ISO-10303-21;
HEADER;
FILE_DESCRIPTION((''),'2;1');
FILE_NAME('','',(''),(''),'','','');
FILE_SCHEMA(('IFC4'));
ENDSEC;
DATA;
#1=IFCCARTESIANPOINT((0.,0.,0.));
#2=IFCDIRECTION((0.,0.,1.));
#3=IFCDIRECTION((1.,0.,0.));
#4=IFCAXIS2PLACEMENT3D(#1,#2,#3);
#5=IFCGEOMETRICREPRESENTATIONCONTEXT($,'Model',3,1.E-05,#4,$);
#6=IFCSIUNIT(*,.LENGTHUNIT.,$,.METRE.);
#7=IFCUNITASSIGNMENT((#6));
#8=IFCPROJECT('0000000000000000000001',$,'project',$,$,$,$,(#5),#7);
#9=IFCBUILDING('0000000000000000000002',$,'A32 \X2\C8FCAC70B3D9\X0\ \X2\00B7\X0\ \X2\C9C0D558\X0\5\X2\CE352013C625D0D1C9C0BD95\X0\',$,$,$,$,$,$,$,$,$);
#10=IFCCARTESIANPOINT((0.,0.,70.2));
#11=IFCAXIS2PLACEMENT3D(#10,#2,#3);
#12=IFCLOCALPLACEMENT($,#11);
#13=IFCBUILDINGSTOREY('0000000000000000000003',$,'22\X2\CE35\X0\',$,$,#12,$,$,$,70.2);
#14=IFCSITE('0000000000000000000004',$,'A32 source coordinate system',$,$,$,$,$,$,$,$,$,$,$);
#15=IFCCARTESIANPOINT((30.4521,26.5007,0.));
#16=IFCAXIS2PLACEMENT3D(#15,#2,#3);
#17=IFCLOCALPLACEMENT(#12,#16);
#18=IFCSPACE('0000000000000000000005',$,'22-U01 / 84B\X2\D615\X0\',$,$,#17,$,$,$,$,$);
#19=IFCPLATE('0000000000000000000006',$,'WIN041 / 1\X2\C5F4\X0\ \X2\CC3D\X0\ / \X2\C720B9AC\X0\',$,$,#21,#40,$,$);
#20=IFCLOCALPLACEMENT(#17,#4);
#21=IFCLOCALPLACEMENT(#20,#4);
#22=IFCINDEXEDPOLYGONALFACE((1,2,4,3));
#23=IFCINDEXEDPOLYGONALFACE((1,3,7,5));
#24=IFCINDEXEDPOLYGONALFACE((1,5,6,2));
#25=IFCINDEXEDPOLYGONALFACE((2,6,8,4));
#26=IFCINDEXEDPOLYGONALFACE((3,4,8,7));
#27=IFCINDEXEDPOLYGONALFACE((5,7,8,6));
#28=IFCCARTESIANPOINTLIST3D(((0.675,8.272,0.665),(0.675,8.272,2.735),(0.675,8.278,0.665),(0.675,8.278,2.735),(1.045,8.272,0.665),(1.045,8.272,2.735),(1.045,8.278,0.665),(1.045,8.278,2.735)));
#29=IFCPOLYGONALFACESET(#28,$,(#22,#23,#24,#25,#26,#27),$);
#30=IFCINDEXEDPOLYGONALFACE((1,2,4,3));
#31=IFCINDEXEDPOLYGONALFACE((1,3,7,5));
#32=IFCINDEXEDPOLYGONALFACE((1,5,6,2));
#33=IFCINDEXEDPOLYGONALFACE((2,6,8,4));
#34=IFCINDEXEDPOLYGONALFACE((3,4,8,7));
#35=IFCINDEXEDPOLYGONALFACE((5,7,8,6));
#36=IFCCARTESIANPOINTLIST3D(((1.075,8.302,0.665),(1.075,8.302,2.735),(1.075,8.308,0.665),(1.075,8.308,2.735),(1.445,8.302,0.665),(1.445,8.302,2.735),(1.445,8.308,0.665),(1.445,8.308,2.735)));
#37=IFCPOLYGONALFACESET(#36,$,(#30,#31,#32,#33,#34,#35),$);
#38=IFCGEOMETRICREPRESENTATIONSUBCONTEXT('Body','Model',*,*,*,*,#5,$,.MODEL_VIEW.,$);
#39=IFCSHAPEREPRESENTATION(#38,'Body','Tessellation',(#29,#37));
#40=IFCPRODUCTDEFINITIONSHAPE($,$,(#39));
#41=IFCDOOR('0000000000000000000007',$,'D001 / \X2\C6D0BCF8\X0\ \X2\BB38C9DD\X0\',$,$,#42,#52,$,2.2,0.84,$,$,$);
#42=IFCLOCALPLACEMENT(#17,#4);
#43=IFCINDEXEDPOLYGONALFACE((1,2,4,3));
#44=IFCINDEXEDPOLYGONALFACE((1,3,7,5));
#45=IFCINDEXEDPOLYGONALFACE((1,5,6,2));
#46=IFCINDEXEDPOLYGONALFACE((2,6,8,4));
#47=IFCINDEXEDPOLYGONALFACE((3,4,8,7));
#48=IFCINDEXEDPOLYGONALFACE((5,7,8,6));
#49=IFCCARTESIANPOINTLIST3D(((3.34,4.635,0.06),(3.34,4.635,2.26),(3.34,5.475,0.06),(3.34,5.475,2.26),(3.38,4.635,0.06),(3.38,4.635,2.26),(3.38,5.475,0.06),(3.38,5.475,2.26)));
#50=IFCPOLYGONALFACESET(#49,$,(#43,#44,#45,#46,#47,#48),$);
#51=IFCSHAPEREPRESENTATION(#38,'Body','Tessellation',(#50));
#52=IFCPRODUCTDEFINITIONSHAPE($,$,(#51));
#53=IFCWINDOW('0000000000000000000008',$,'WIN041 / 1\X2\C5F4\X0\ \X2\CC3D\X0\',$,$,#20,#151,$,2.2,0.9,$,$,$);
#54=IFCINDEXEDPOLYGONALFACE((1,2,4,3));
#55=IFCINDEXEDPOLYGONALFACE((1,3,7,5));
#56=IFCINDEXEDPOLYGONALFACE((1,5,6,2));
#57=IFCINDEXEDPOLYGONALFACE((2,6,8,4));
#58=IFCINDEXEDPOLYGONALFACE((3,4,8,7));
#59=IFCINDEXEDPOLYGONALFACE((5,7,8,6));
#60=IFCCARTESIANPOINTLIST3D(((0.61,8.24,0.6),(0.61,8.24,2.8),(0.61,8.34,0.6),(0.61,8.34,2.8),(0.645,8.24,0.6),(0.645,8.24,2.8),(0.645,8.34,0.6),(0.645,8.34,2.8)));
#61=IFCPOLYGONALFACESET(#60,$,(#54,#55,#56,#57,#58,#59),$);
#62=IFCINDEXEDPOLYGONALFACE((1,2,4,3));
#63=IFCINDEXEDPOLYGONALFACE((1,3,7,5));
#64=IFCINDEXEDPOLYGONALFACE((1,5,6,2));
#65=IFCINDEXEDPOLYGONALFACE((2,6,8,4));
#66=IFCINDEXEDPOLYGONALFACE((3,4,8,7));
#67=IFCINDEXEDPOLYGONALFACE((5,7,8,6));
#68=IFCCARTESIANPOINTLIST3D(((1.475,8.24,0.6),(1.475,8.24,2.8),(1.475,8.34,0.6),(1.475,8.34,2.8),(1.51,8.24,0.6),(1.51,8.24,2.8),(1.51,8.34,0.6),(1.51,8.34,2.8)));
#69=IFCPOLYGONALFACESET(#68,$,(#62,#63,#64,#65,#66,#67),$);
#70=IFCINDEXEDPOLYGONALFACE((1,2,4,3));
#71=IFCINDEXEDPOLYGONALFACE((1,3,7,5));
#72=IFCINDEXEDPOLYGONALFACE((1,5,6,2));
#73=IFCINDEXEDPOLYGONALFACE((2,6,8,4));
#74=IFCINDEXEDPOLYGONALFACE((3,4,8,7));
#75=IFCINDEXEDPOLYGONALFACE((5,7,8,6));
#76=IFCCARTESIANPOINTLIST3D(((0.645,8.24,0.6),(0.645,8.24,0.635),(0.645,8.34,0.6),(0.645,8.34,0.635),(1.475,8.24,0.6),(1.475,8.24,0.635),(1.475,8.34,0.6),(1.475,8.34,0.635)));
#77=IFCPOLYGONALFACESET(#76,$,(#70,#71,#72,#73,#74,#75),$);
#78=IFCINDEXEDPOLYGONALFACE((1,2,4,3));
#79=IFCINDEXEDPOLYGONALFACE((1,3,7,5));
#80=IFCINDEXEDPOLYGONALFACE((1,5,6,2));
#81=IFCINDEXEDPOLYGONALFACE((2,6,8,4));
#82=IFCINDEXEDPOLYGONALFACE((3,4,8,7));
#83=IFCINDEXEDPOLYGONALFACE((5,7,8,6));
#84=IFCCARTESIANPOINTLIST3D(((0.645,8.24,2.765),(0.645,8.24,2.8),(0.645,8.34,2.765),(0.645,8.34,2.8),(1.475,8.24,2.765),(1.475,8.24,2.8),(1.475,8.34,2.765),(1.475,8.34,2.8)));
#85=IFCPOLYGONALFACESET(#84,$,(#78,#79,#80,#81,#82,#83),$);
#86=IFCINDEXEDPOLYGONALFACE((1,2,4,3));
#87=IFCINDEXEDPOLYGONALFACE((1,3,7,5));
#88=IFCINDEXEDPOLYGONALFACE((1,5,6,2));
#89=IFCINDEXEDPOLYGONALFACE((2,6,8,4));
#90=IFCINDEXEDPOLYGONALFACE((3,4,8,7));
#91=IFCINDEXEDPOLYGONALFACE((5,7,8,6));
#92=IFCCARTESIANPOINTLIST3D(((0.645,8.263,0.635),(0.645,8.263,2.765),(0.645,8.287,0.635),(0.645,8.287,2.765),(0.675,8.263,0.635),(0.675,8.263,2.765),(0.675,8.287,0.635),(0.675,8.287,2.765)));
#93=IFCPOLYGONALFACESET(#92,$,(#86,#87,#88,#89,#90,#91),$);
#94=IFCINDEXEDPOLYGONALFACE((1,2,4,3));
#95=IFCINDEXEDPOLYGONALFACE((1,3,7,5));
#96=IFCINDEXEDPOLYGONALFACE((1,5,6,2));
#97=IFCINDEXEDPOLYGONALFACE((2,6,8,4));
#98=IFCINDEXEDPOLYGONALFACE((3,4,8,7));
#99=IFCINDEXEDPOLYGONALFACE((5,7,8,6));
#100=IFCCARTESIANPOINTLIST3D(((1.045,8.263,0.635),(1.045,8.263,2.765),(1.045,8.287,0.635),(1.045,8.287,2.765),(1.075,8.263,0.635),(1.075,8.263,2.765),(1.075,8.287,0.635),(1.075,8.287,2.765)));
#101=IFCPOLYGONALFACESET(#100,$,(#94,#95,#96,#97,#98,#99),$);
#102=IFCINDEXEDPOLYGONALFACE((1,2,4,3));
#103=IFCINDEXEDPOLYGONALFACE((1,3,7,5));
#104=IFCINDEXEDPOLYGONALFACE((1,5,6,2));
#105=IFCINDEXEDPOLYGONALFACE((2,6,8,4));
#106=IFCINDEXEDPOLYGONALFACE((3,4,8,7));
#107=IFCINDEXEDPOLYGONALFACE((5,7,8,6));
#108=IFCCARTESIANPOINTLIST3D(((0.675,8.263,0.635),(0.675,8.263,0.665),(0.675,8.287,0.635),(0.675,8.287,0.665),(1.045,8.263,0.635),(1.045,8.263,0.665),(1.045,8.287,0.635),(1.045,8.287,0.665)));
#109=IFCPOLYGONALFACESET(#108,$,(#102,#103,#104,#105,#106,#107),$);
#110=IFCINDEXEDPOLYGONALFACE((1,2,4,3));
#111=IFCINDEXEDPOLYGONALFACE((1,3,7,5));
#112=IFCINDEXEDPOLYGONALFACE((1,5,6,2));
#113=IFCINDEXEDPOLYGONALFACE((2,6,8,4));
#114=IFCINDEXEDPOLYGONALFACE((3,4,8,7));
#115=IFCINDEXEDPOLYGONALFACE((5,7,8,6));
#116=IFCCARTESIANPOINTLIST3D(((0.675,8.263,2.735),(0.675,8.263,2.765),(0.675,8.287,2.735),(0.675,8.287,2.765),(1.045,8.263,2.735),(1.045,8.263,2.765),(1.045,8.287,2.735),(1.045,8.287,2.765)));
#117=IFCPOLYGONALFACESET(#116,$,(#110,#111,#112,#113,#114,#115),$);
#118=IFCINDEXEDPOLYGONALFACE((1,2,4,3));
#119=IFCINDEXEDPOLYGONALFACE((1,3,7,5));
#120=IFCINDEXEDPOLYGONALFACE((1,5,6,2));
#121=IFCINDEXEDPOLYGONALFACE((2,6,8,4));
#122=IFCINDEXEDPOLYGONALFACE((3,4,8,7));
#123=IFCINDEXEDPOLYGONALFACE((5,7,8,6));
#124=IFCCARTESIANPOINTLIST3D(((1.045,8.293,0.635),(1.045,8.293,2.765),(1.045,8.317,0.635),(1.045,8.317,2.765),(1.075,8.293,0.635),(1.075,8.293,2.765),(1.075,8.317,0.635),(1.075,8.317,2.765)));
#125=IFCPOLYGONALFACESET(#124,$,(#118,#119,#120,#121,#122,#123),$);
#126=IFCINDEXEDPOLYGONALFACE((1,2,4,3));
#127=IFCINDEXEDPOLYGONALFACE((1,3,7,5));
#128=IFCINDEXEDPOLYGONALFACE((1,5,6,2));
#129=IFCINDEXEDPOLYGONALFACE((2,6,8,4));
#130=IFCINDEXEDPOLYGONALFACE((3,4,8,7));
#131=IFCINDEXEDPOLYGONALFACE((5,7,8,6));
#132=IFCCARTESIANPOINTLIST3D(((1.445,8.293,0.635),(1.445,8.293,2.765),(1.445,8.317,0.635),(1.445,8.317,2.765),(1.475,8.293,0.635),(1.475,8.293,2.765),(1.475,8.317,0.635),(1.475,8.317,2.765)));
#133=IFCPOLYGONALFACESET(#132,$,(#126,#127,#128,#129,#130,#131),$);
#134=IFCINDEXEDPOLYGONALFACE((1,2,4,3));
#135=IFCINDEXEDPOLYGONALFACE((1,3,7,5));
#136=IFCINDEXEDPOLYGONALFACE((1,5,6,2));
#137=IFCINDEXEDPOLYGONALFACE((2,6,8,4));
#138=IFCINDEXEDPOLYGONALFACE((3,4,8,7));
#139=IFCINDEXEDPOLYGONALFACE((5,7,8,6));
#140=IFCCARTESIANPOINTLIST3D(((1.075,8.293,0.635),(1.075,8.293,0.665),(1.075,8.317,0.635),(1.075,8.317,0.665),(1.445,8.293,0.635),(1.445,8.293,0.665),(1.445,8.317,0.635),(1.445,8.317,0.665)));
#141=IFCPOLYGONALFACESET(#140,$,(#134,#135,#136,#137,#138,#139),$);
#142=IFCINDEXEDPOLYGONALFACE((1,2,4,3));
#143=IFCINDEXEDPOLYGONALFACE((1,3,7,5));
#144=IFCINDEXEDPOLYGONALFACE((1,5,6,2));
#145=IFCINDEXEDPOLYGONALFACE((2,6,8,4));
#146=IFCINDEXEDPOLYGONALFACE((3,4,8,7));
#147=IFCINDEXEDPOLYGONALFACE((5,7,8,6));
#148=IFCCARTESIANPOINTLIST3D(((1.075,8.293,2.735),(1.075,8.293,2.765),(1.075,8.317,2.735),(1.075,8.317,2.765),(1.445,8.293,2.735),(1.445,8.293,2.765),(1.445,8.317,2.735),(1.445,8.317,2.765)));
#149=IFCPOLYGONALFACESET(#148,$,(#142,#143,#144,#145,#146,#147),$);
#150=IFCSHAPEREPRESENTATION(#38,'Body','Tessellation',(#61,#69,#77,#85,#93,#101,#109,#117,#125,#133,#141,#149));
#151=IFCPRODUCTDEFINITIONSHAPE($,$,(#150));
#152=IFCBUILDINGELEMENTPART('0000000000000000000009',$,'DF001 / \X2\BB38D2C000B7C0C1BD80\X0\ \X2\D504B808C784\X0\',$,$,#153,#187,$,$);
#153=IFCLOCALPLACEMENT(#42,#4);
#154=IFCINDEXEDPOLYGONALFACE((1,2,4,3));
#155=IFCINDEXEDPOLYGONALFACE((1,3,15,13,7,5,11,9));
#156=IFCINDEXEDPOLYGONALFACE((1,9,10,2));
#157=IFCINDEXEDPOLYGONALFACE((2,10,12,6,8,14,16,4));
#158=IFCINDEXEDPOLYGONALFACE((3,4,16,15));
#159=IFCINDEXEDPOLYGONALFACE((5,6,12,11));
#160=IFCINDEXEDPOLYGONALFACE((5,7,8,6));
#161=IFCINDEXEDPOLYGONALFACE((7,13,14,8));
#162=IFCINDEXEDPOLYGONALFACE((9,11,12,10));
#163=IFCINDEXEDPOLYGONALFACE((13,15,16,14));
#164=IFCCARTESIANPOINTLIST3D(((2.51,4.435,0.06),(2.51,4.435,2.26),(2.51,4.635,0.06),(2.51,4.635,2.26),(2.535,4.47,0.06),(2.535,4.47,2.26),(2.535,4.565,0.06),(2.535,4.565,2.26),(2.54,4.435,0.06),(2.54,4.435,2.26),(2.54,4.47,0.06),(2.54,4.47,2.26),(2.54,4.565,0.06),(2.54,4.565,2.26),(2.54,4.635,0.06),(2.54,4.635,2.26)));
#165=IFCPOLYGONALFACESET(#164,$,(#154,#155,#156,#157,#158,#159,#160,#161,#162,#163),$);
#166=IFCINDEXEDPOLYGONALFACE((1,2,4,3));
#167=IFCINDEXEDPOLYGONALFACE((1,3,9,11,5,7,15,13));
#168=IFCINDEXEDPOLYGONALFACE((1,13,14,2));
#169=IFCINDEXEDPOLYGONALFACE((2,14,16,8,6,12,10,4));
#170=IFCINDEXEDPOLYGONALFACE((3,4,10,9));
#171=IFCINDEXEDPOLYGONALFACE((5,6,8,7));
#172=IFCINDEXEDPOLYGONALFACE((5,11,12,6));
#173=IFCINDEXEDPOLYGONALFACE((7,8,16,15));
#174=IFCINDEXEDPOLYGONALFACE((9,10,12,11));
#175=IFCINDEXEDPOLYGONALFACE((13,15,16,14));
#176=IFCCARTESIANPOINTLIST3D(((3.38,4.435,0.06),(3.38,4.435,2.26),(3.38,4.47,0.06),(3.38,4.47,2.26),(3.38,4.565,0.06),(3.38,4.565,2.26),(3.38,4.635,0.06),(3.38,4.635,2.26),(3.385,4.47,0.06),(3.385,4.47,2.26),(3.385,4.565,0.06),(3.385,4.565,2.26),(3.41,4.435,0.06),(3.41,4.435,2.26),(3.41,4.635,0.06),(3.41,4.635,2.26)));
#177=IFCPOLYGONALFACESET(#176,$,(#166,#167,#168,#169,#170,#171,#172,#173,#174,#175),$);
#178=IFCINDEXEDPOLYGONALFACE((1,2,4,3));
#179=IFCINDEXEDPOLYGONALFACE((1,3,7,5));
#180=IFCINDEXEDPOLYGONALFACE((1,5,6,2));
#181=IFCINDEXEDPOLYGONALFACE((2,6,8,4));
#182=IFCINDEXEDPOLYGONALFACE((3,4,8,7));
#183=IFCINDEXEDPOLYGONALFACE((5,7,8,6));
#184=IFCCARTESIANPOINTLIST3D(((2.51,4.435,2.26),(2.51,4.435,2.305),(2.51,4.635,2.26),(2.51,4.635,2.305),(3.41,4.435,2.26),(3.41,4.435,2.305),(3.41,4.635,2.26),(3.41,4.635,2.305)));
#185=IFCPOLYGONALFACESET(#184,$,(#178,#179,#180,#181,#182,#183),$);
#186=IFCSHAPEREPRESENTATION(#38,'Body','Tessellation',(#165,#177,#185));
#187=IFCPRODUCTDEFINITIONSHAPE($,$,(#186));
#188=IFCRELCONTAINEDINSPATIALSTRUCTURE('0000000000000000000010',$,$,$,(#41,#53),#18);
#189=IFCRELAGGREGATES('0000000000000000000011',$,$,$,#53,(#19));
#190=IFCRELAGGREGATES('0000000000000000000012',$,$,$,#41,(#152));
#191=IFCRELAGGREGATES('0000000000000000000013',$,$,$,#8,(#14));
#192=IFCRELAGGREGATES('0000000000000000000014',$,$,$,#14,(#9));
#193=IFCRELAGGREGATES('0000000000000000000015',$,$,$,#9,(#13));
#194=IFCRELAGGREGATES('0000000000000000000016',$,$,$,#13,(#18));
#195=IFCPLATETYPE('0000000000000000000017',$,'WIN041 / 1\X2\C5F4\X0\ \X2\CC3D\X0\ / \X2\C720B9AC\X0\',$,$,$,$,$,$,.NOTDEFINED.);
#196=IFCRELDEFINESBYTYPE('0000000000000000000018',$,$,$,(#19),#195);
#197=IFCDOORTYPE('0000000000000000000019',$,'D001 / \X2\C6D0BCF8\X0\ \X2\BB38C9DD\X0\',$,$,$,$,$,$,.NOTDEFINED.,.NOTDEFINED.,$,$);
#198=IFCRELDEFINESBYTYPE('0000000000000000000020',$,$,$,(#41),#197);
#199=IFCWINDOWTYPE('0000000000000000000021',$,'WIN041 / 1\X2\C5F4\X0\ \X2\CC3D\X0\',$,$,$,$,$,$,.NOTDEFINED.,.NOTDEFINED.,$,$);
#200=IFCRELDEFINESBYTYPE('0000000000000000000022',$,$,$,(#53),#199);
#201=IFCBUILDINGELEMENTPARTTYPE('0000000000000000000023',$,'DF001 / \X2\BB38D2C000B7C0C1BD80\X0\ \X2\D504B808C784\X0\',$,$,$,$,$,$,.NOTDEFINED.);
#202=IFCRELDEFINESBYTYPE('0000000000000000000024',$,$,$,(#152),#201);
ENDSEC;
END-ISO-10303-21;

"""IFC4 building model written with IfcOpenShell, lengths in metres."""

from ifc_helpers import new_model, si_unit, frame, origin, origin_with_axes, place, context, subcontext, project, spatial, polyline, outline, extrude, source, transform, mapped, type_object, type_shapes, element, aggregate, save


model = new_model("IFC4")

# Units and contexts
model_context = context("Model", 3, precision=1e-05, world=origin_with_axes())
body_context = subcontext(model_context, "Body", "Model", "MODEL_VIEW")
ifc_project = project(units=[si_unit("LENGTHUNIT", "METRE")], contexts=[model_context])

# Plate
storey_placement = place(None, frame((0.0, 0.0, 70.2), z_axis=(0.0, 0.0, 1.0), x_axis=(1.0, 0.0, 0.0)))
space_placement = place(storey_placement, frame((30.4521, 26.5007, 0.0), z_axis=(0.0, 0.0, 1.0), x_axis=(1.0, 0.0, 0.0)))
plate_type_1 = type_object("IfcPlateType", Name="WIN041 / 1열 창 / 유리", PredefinedType="NOTDEFINED")
shared_shape_1 = source(origin(), body_context, "Body", "SweptSolid", [
    extrude(outline(polyline([(0.675, 8.272), (0.675, 8.278), (1.045, 8.278), (1.045, 8.272), (0.675, 8.272)])), frame((0.0, 0.0, 0.665)), (0.0, 0.0, 1.0), 2.07),
    extrude(outline(polyline([(1.075, 8.302), (1.075, 8.308), (1.445, 8.308), (1.445, 8.302), (1.075, 8.302)])), frame((0.0, 0.0, 0.665)), (0.0, 0.0, 1.0), 2.07),
])
type_shapes(plate_type_1, [shared_shape_1])
window_1_placement = place(space_placement, origin_with_axes())
plate_1_placement = place(window_1_placement, origin_with_axes())
plate_1 = element("IfcPlate", 1, at=plate_1_placement, type_object=plate_type_1, Name="WIN041 / 1열 창 / 유리", context=body_context, shape_type="MappedRepresentation", body=[
    mapped(shared_shape_1, transform((0.0, 0.0, 0.0), scale=1.0)),
])

# Site, building, storey, space
site = spatial("IfcSite", under=ifc_project, Name="A32 source coordinate system")
building = spatial("IfcBuilding", under=site, Name="A32 주거동 · 지하5층–옥탑지붕")
storey = spatial("IfcBuildingStorey", under=building, at=storey_placement, Name="22층", Elevation=70.2)
space = spatial("IfcSpace", under=storey, at=space_placement, Name="22-U01 / 84B형")

# Door
door_type_1 = type_object("IfcDoorType", Name="D001 / 원본 문짝", OperationType="NOTDEFINED", PredefinedType="NOTDEFINED")
shared_shape_2 = source(origin(), body_context, "Body", "SweptSolid", [
    extrude(outline(polyline([(3.34, 5.475), (3.38, 5.475), (3.38, 4.635), (3.34, 4.635), (3.34, 5.475)])), frame((0.0, 0.0, 0.06)), (0.0, 0.0, 1.0), 2.2),
])
type_shapes(door_type_1, [shared_shape_2])
door_1_placement = place(space_placement, origin_with_axes())
door_1 = element("IfcDoor", 2, at=door_1_placement, inside=space, type_object=door_type_1, Name="D001 / 원본 문짝", OverallHeight=2.2, OverallWidth=0.84, context=body_context, shape_type="MappedRepresentation", body=[
    mapped(shared_shape_2, transform((0.0, 0.0, 0.0), scale=1.0)),
])

# Window
window_type_1 = type_object("IfcWindowType", Name="WIN041 / 1열 창", PartitioningType="NOTDEFINED", PredefinedType="NOTDEFINED")
shared_shape_3 = source(origin(), body_context, "Body", "SweptSolid", [
    extrude(outline(polyline([(0.61, 8.24), (0.61, 8.34), (0.645, 8.34), (0.645, 8.24), (0.61, 8.24)])), frame((0.0, 0.0, 0.6)), (0.0, 0.0, 1.0), 2.2),
    extrude(outline(polyline([(1.475, 8.24), (1.475, 8.34), (1.51, 8.34), (1.51, 8.24), (1.475, 8.24)])), frame((0.0, 0.0, 0.6)), (0.0, 0.0, 1.0), 2.2),
    extrude(outline(polyline([(0.645, 8.24), (0.645, 8.34), (1.475, 8.34), (1.475, 8.24), (0.645, 8.24)])), frame((0.0, 0.0, 0.6)), (0.0, 0.0, 1.0), 0.035),
    extrude(outline(polyline([(0.645, 8.24), (0.645, 8.34), (1.475, 8.34), (1.475, 8.24), (0.645, 8.24)])), frame((0.0, 0.0, 2.765)), (0.0, 0.0, 1.0), 0.035),
    extrude(outline(polyline([(0.645, 8.263), (0.645, 8.287), (0.675, 8.287), (0.675, 8.263), (0.645, 8.263)])), frame((0.0, 0.0, 0.635)), (0.0, 0.0, 1.0), 2.13),
    extrude(outline(polyline([(1.045, 8.263), (1.045, 8.287), (1.075, 8.287), (1.075, 8.263), (1.045, 8.263)])), frame((0.0, 0.0, 0.635)), (0.0, 0.0, 1.0), 2.13),
    extrude(outline(polyline([(0.675, 8.263), (0.675, 8.287), (1.045, 8.287), (1.045, 8.263), (0.675, 8.263)])), frame((0.0, 0.0, 0.635)), (0.0, 0.0, 1.0), 0.03),
    extrude(outline(polyline([(0.675, 8.263), (0.675, 8.287), (1.045, 8.287), (1.045, 8.263), (0.675, 8.263)])), frame((0.0, 0.0, 2.735)), (0.0, 0.0, 1.0), 0.03),
    extrude(outline(polyline([(1.045, 8.293), (1.045, 8.317), (1.075, 8.317), (1.075, 8.293), (1.045, 8.293)])), frame((0.0, 0.0, 0.635)), (0.0, 0.0, 1.0), 2.13),
    extrude(outline(polyline([(1.445, 8.293), (1.445, 8.317), (1.475, 8.317), (1.475, 8.293), (1.445, 8.293)])), frame((0.0, 0.0, 0.635)), (0.0, 0.0, 1.0), 2.13),
    extrude(outline(polyline([(1.075, 8.293), (1.075, 8.317), (1.445, 8.317), (1.445, 8.293), (1.075, 8.293)])), frame((0.0, 0.0, 0.635)), (0.0, 0.0, 1.0), 0.03),
    extrude(outline(polyline([(1.075, 8.293), (1.075, 8.317), (1.445, 8.317), (1.445, 8.293), (1.075, 8.293)])), frame((0.0, 0.0, 2.735)), (0.0, 0.0, 1.0), 0.03),
])
type_shapes(window_type_1, [shared_shape_3])
window_1 = element("IfcWindow", 3, at=window_1_placement, inside=space, type_object=window_type_1, Name="WIN041 / 1열 창", OverallHeight=2.2, OverallWidth=0.9, context=body_context, shape_type="MappedRepresentation", body=[
    mapped(shared_shape_3, transform((0.0, 0.0, 0.0), scale=1.0)),
])
aggregate(window_1, [plate_1])

# Building element part
building_element_part_type_1 = type_object("IfcBuildingElementPartType", Name="DF001 / 문틀·상부 프레임", PredefinedType="NOTDEFINED")
shared_shape_4 = source(origin(), body_context, "Body", "SweptSolid", [
    extrude(outline(polyline([(2.54, 4.635), (2.54, 4.565), (2.535, 4.565), (2.535, 4.47), (2.54, 4.47), (2.54, 4.435), (2.51, 4.435), (2.51, 4.635), (2.54, 4.635)])), frame((0.0, 0.0, 0.06)), (0.0, 0.0, 1.0), 2.2),
    extrude(outline(polyline([(3.41, 4.435), (3.38, 4.435), (3.38, 4.47), (3.385, 4.47), (3.385, 4.565), (3.38, 4.565), (3.38, 4.635), (3.41, 4.635), (3.41, 4.435)])), frame((0.0, 0.0, 0.06)), (0.0, 0.0, 1.0), 2.2),
    extrude(outline(polyline([(2.51, 4.435), (2.51, 4.635), (3.41, 4.635), (3.41, 4.435), (2.51, 4.435)])), frame((0.0, 0.0, 2.26)), (0.0, 0.0, 1.0), 0.045),
])
type_shapes(building_element_part_type_1, [shared_shape_4])
building_element_part_1_placement = place(door_1_placement, origin_with_axes())
building_element_part_1 = element("IfcBuildingElementPart", 4, at=building_element_part_1_placement, type_object=building_element_part_type_1, Name="DF001 / 문틀·상부 프레임", context=body_context, shape_type="MappedRepresentation", body=[
    mapped(shared_shape_4, transform((0.0, 0.0, 0.0), scale=1.0)),
])
aggregate(door_1, [building_element_part_1])

save(model, "model.ifc")
